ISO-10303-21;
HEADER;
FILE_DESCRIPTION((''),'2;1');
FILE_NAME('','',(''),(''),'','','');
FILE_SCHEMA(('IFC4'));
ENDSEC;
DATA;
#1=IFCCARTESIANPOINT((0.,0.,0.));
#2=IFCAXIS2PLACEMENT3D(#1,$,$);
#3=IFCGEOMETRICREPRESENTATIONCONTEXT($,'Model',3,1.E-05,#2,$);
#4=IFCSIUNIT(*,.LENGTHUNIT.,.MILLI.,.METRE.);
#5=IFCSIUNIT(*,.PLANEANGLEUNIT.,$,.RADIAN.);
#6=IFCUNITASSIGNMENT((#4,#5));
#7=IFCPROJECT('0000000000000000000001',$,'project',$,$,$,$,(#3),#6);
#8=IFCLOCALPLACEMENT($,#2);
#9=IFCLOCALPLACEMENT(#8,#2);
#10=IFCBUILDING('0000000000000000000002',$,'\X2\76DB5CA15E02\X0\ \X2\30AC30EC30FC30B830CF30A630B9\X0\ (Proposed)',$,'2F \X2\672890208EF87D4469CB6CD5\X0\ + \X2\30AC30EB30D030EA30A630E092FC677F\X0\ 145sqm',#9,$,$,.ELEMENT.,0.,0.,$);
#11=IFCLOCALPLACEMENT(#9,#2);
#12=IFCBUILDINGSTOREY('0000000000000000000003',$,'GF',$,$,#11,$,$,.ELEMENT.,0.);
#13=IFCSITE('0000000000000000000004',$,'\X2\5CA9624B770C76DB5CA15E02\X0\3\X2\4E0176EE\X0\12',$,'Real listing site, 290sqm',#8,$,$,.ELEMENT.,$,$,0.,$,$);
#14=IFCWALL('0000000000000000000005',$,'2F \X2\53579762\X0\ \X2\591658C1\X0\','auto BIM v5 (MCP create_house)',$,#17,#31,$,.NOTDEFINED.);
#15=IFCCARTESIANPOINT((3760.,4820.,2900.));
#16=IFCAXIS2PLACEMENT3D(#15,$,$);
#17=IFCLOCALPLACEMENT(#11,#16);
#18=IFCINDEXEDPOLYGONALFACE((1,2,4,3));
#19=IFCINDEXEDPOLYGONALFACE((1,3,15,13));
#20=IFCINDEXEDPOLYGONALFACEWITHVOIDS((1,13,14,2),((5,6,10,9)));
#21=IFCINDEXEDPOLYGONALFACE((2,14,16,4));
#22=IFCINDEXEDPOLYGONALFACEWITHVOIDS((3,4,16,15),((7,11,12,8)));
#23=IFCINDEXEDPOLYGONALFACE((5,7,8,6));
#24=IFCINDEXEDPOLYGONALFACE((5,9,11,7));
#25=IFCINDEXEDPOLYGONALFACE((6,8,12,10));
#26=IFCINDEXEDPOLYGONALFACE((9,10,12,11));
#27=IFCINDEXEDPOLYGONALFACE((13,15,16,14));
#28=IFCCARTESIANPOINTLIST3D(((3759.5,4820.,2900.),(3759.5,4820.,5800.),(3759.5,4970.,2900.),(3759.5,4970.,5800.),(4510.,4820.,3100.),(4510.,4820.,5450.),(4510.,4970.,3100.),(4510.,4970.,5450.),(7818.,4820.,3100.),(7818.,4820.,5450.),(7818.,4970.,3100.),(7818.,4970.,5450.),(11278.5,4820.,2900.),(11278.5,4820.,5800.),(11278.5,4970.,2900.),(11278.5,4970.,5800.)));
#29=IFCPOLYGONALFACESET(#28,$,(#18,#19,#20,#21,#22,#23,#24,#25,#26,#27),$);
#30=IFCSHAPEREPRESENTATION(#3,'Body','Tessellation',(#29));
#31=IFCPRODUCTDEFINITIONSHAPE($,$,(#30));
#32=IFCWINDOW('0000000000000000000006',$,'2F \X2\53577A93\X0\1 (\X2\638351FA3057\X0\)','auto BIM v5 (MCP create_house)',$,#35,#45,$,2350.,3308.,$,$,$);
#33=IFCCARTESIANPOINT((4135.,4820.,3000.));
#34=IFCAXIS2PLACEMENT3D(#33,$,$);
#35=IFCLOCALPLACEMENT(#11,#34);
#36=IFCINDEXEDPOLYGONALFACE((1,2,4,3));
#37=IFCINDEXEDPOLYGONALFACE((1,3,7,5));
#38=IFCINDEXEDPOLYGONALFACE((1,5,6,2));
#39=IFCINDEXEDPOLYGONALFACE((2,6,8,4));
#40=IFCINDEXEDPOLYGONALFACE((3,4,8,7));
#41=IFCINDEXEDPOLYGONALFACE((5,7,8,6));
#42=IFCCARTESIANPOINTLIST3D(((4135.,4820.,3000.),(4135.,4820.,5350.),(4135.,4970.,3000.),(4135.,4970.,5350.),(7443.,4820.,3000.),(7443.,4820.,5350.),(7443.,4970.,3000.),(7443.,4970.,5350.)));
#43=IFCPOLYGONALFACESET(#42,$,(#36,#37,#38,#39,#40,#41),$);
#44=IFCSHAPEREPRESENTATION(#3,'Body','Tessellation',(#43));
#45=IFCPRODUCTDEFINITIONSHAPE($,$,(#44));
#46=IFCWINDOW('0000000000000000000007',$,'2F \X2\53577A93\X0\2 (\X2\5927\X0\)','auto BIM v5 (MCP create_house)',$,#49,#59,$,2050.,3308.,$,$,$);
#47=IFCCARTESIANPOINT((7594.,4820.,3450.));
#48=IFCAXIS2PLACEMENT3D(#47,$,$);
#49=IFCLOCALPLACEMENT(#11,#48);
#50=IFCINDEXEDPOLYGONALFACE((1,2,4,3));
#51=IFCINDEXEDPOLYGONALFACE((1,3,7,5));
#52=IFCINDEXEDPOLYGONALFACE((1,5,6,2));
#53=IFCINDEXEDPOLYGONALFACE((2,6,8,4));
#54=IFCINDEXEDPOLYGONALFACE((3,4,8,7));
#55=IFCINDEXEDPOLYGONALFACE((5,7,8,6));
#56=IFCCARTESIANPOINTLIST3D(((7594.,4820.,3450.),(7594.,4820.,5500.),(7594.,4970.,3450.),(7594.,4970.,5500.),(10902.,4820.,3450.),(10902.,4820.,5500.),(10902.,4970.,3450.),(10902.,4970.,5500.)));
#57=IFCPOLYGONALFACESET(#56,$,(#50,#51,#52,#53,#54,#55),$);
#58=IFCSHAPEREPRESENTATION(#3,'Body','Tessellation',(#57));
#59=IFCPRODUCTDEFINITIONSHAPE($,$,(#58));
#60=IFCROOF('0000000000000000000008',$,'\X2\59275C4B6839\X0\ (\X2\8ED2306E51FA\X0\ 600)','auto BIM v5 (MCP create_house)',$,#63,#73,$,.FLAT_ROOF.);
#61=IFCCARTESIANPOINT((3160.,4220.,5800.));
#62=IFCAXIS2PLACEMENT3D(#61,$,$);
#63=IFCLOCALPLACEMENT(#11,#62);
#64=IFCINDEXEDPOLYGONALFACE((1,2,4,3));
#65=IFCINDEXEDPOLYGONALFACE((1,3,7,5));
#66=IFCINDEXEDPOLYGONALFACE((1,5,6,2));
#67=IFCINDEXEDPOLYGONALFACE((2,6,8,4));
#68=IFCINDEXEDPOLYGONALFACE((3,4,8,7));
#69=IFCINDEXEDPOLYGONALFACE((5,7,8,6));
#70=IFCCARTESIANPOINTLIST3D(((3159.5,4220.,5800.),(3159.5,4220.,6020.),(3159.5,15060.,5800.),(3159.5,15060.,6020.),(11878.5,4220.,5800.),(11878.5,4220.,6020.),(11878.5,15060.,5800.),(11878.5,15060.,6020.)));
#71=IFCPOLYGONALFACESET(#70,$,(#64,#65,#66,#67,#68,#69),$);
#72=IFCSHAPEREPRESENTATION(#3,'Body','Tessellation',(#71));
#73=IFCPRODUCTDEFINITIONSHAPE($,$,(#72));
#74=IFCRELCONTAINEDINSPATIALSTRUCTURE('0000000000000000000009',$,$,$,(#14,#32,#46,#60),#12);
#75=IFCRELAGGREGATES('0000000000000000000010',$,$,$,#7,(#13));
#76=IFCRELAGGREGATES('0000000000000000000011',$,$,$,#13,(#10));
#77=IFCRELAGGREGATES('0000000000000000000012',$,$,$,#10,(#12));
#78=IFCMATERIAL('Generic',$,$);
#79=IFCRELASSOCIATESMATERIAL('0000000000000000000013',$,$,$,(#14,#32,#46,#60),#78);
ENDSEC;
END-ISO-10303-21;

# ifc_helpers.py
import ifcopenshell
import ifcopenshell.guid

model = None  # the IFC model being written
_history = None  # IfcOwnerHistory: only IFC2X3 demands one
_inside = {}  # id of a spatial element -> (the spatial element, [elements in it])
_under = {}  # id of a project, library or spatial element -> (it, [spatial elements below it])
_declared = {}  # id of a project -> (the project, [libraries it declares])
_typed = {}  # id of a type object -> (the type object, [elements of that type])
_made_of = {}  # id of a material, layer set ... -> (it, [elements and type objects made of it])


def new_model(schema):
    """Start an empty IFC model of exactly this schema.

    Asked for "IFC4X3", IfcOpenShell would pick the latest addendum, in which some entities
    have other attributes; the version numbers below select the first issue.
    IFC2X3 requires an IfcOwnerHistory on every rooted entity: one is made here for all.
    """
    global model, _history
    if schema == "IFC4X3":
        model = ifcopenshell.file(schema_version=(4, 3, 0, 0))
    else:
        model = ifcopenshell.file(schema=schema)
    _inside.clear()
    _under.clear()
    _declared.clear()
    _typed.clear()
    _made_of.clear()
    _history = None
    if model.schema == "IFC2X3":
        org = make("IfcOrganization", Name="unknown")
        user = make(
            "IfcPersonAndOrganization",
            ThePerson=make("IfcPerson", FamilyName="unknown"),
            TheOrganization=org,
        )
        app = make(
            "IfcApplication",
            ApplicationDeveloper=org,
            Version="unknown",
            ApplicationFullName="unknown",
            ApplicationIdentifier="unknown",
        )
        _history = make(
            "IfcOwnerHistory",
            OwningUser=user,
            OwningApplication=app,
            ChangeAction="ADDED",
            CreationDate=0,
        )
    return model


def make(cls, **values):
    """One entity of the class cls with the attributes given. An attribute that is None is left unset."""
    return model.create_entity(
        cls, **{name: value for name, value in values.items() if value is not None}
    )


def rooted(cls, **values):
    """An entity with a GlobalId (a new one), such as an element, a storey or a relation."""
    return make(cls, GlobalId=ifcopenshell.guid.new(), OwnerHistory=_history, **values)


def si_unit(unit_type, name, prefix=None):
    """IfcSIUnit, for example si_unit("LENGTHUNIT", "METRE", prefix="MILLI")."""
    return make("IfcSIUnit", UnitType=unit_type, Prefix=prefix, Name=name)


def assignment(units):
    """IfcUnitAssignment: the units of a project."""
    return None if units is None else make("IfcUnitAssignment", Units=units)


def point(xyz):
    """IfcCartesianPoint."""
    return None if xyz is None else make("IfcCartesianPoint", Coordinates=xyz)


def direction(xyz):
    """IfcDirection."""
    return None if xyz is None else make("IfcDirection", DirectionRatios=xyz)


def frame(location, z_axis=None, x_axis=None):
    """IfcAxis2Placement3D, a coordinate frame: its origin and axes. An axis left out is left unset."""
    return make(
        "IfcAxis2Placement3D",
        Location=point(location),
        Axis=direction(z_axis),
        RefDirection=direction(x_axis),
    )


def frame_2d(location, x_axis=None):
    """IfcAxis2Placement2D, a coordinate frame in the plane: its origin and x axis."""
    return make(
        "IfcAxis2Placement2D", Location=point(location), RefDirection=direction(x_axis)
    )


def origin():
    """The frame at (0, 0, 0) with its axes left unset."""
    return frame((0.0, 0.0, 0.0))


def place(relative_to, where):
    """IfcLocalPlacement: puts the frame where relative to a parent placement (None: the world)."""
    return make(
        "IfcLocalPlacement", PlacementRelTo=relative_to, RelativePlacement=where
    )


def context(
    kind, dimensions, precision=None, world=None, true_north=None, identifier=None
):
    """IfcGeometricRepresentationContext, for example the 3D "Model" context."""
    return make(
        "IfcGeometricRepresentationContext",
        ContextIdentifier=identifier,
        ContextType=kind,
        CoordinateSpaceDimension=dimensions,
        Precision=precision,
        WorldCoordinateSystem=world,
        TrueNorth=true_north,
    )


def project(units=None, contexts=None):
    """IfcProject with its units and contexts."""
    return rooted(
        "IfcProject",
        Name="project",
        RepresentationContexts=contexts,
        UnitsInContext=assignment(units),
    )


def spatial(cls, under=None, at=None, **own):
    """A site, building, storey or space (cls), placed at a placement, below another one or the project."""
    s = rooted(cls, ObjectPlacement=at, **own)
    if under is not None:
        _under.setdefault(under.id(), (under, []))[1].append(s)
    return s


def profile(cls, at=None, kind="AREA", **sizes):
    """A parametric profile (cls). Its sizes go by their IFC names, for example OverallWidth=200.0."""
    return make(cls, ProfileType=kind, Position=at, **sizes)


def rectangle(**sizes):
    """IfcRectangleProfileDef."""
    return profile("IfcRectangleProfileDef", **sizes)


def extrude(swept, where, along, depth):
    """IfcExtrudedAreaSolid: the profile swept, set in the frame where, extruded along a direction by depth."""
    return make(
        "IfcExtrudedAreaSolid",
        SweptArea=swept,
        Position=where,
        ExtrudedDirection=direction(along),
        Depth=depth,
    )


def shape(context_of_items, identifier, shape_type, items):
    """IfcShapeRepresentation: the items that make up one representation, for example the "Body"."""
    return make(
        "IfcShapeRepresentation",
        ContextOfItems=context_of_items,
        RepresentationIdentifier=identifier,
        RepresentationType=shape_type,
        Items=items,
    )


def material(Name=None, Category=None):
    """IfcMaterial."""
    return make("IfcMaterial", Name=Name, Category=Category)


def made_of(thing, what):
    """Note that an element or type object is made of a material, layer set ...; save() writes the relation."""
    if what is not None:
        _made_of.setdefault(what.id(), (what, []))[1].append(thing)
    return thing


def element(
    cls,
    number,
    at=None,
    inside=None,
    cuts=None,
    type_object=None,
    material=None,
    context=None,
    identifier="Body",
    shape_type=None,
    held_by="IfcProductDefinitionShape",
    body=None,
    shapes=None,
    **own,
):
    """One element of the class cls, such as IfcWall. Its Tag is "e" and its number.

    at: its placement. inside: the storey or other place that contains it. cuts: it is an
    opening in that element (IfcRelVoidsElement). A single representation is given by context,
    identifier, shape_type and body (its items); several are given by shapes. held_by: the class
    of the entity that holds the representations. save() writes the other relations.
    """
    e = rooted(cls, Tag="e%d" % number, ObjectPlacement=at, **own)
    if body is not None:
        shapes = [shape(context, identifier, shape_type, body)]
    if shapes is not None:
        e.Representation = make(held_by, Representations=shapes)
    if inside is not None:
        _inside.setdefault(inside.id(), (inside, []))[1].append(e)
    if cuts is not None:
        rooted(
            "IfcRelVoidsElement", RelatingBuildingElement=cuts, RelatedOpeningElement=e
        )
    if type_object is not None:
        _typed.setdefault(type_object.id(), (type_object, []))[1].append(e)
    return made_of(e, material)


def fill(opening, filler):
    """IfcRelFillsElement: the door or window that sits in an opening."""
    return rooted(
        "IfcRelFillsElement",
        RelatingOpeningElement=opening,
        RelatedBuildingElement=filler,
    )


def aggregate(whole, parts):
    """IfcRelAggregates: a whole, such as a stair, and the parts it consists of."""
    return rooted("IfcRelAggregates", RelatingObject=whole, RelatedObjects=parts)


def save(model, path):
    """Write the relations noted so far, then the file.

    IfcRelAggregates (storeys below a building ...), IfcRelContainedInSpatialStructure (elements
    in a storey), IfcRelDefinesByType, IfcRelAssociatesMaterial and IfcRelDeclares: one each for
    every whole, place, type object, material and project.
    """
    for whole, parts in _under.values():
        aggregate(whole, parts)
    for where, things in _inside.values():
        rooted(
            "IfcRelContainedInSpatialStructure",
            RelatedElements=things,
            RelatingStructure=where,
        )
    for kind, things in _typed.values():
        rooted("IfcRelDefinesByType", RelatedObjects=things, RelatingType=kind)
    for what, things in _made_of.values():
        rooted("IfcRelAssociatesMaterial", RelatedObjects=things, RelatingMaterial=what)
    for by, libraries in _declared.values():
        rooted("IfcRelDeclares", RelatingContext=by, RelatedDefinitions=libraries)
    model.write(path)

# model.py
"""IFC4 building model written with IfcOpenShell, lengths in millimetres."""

from ifc_helpers import new_model, si_unit, frame, frame_2d, origin, place, context, project, spatial, rectangle, extrude, material, element, fill, save


model = new_model("IFC4")

# Units and contexts
model_context = context("Model", 3, precision=1e-05, world=origin())
ifc_project = project(units=[si_unit("LENGTHUNIT", "METRE", prefix="MILLI"), si_unit("PLANEANGLEUNIT", "RADIAN")], contexts=[model_context])

# Site, building, storey
site_placement = place(None, origin())
site = spatial("IfcSite", under=ifc_project, at=site_placement, Name="岩手県盛岡市3丁目12", ObjectType="Real listing site, 290sqm", CompositionType="ELEMENT", RefElevation=0.0)
building_placement = place(site_placement, origin())
building = spatial("IfcBuilding", under=site, at=building_placement, Name="盛岡市 ガレージハウス (Proposed)", ObjectType="2F 木造軸組構法 + ガルバリウム鋼板 145sqm", CompositionType="ELEMENT", ElevationOfRefHeight=0.0, ElevationOfTerrain=0.0)
storey_placement = place(building_placement, origin())
storey = spatial("IfcBuildingStorey", under=building, at=storey_placement, Name="GF", CompositionType="ELEMENT", Elevation=0.0)

# Shared definitions
ifc_material = material(Name="Generic")

# Wall, openings, windows
wall_1_placement = place(storey_placement, frame((3760.0, 4820.0, 2900.0)))
wall_1 = element("IfcWall", 1, at=wall_1_placement, inside=storey, material=ifc_material, Name="2F 南面 外壁", Description="auto BIM v5 (MCP create_house)", PredefinedType="NOTDEFINED", context=model_context, shape_type="SweptSolid", body=[
    extrude(rectangle(XDim=7519.0, YDim=150.0, at=frame_2d((3759.0, 75.0))), frame((3760.0, 4820.0, 2900.0)), (0.0, 0.0, 1.0), 2900.0),
])
opening_1_placement = place(storey_placement, frame((4135.0, 4820.0, 3000.0)))
opening_1 = element("IfcOpeningElement", 2, at=opening_1_placement, cuts=wall_1, PredefinedType="NOTDEFINED", context=model_context, shape_type="SweptSolid", body=[
    extrude(rectangle(XDim=3308.0, YDim=150.0, at=frame_2d((1654.0, 75.0))), frame((4135.0, 4820.0, 3000.0)), (0.0, 0.0, 1.0), 2350.0),
])
opening_2_placement = place(storey_placement, frame((7594.0, 4820.0, 3450.0)))
opening_2 = element("IfcOpeningElement", 3, at=opening_2_placement, cuts=wall_1, PredefinedType="NOTDEFINED", context=model_context, shape_type="SweptSolid", body=[
    extrude(rectangle(XDim=3308.0, YDim=150.0, at=frame_2d((1654.0, 75.0))), frame((7594.0, 4820.0, 3450.0)), (0.0, 0.0, 1.0), 2050.0),
])
window_1_placement = place(storey_placement, frame((4135.0, 4820.0, 3000.0)))
window_1 = element("IfcWindow", 4, at=window_1_placement, inside=storey, material=ifc_material, Name="2F 南窓1 (掃出し)", Description="auto BIM v5 (MCP create_house)", OverallHeight=2350.0, OverallWidth=3308.0, context=model_context, shape_type="SweptSolid", body=[
    extrude(rectangle(XDim=3308.0, YDim=150.0, at=frame_2d((1654.0, 75.0))), frame((4135.0, 4820.0, 3000.0)), (0.0, 0.0, 1.0), 2350.0),
])
fill(opening_1, window_1)
window_2_placement = place(storey_placement, frame((7594.0, 4820.0, 3450.0)))
window_2 = element("IfcWindow", 5, at=window_2_placement, inside=storey, material=ifc_material, Name="2F 南窓2 (大)", Description="auto BIM v5 (MCP create_house)", OverallHeight=2050.0, OverallWidth=3308.0, context=model_context, shape_type="SweptSolid", body=[
    extrude(rectangle(XDim=3308.0, YDim=150.0, at=frame_2d((1654.0, 75.0))), frame((7594.0, 4820.0, 3450.0)), (0.0, 0.0, 1.0), 2050.0),
])
fill(opening_2, window_2)

# Roof
roof_placement = place(storey_placement, frame((3160.0, 4220.0, 5800.0)))
element("IfcRoof", 6, at=roof_placement, inside=storey, material=ifc_material, Name="大屋根 (軒の出 600)", Description="auto BIM v5 (MCP create_house)", PredefinedType="FLAT_ROOF", context=model_context, shape_type="SweptSolid", body=[
    extrude(rectangle(XDim=8719.0, YDim=10840.0, at=frame_2d((4359.0, 5420.0))), frame((3160.0, 4220.0, 5800.0)), (0.0, 0.0, 1.0), 220.0),
])

save(model, "model.ifc")
